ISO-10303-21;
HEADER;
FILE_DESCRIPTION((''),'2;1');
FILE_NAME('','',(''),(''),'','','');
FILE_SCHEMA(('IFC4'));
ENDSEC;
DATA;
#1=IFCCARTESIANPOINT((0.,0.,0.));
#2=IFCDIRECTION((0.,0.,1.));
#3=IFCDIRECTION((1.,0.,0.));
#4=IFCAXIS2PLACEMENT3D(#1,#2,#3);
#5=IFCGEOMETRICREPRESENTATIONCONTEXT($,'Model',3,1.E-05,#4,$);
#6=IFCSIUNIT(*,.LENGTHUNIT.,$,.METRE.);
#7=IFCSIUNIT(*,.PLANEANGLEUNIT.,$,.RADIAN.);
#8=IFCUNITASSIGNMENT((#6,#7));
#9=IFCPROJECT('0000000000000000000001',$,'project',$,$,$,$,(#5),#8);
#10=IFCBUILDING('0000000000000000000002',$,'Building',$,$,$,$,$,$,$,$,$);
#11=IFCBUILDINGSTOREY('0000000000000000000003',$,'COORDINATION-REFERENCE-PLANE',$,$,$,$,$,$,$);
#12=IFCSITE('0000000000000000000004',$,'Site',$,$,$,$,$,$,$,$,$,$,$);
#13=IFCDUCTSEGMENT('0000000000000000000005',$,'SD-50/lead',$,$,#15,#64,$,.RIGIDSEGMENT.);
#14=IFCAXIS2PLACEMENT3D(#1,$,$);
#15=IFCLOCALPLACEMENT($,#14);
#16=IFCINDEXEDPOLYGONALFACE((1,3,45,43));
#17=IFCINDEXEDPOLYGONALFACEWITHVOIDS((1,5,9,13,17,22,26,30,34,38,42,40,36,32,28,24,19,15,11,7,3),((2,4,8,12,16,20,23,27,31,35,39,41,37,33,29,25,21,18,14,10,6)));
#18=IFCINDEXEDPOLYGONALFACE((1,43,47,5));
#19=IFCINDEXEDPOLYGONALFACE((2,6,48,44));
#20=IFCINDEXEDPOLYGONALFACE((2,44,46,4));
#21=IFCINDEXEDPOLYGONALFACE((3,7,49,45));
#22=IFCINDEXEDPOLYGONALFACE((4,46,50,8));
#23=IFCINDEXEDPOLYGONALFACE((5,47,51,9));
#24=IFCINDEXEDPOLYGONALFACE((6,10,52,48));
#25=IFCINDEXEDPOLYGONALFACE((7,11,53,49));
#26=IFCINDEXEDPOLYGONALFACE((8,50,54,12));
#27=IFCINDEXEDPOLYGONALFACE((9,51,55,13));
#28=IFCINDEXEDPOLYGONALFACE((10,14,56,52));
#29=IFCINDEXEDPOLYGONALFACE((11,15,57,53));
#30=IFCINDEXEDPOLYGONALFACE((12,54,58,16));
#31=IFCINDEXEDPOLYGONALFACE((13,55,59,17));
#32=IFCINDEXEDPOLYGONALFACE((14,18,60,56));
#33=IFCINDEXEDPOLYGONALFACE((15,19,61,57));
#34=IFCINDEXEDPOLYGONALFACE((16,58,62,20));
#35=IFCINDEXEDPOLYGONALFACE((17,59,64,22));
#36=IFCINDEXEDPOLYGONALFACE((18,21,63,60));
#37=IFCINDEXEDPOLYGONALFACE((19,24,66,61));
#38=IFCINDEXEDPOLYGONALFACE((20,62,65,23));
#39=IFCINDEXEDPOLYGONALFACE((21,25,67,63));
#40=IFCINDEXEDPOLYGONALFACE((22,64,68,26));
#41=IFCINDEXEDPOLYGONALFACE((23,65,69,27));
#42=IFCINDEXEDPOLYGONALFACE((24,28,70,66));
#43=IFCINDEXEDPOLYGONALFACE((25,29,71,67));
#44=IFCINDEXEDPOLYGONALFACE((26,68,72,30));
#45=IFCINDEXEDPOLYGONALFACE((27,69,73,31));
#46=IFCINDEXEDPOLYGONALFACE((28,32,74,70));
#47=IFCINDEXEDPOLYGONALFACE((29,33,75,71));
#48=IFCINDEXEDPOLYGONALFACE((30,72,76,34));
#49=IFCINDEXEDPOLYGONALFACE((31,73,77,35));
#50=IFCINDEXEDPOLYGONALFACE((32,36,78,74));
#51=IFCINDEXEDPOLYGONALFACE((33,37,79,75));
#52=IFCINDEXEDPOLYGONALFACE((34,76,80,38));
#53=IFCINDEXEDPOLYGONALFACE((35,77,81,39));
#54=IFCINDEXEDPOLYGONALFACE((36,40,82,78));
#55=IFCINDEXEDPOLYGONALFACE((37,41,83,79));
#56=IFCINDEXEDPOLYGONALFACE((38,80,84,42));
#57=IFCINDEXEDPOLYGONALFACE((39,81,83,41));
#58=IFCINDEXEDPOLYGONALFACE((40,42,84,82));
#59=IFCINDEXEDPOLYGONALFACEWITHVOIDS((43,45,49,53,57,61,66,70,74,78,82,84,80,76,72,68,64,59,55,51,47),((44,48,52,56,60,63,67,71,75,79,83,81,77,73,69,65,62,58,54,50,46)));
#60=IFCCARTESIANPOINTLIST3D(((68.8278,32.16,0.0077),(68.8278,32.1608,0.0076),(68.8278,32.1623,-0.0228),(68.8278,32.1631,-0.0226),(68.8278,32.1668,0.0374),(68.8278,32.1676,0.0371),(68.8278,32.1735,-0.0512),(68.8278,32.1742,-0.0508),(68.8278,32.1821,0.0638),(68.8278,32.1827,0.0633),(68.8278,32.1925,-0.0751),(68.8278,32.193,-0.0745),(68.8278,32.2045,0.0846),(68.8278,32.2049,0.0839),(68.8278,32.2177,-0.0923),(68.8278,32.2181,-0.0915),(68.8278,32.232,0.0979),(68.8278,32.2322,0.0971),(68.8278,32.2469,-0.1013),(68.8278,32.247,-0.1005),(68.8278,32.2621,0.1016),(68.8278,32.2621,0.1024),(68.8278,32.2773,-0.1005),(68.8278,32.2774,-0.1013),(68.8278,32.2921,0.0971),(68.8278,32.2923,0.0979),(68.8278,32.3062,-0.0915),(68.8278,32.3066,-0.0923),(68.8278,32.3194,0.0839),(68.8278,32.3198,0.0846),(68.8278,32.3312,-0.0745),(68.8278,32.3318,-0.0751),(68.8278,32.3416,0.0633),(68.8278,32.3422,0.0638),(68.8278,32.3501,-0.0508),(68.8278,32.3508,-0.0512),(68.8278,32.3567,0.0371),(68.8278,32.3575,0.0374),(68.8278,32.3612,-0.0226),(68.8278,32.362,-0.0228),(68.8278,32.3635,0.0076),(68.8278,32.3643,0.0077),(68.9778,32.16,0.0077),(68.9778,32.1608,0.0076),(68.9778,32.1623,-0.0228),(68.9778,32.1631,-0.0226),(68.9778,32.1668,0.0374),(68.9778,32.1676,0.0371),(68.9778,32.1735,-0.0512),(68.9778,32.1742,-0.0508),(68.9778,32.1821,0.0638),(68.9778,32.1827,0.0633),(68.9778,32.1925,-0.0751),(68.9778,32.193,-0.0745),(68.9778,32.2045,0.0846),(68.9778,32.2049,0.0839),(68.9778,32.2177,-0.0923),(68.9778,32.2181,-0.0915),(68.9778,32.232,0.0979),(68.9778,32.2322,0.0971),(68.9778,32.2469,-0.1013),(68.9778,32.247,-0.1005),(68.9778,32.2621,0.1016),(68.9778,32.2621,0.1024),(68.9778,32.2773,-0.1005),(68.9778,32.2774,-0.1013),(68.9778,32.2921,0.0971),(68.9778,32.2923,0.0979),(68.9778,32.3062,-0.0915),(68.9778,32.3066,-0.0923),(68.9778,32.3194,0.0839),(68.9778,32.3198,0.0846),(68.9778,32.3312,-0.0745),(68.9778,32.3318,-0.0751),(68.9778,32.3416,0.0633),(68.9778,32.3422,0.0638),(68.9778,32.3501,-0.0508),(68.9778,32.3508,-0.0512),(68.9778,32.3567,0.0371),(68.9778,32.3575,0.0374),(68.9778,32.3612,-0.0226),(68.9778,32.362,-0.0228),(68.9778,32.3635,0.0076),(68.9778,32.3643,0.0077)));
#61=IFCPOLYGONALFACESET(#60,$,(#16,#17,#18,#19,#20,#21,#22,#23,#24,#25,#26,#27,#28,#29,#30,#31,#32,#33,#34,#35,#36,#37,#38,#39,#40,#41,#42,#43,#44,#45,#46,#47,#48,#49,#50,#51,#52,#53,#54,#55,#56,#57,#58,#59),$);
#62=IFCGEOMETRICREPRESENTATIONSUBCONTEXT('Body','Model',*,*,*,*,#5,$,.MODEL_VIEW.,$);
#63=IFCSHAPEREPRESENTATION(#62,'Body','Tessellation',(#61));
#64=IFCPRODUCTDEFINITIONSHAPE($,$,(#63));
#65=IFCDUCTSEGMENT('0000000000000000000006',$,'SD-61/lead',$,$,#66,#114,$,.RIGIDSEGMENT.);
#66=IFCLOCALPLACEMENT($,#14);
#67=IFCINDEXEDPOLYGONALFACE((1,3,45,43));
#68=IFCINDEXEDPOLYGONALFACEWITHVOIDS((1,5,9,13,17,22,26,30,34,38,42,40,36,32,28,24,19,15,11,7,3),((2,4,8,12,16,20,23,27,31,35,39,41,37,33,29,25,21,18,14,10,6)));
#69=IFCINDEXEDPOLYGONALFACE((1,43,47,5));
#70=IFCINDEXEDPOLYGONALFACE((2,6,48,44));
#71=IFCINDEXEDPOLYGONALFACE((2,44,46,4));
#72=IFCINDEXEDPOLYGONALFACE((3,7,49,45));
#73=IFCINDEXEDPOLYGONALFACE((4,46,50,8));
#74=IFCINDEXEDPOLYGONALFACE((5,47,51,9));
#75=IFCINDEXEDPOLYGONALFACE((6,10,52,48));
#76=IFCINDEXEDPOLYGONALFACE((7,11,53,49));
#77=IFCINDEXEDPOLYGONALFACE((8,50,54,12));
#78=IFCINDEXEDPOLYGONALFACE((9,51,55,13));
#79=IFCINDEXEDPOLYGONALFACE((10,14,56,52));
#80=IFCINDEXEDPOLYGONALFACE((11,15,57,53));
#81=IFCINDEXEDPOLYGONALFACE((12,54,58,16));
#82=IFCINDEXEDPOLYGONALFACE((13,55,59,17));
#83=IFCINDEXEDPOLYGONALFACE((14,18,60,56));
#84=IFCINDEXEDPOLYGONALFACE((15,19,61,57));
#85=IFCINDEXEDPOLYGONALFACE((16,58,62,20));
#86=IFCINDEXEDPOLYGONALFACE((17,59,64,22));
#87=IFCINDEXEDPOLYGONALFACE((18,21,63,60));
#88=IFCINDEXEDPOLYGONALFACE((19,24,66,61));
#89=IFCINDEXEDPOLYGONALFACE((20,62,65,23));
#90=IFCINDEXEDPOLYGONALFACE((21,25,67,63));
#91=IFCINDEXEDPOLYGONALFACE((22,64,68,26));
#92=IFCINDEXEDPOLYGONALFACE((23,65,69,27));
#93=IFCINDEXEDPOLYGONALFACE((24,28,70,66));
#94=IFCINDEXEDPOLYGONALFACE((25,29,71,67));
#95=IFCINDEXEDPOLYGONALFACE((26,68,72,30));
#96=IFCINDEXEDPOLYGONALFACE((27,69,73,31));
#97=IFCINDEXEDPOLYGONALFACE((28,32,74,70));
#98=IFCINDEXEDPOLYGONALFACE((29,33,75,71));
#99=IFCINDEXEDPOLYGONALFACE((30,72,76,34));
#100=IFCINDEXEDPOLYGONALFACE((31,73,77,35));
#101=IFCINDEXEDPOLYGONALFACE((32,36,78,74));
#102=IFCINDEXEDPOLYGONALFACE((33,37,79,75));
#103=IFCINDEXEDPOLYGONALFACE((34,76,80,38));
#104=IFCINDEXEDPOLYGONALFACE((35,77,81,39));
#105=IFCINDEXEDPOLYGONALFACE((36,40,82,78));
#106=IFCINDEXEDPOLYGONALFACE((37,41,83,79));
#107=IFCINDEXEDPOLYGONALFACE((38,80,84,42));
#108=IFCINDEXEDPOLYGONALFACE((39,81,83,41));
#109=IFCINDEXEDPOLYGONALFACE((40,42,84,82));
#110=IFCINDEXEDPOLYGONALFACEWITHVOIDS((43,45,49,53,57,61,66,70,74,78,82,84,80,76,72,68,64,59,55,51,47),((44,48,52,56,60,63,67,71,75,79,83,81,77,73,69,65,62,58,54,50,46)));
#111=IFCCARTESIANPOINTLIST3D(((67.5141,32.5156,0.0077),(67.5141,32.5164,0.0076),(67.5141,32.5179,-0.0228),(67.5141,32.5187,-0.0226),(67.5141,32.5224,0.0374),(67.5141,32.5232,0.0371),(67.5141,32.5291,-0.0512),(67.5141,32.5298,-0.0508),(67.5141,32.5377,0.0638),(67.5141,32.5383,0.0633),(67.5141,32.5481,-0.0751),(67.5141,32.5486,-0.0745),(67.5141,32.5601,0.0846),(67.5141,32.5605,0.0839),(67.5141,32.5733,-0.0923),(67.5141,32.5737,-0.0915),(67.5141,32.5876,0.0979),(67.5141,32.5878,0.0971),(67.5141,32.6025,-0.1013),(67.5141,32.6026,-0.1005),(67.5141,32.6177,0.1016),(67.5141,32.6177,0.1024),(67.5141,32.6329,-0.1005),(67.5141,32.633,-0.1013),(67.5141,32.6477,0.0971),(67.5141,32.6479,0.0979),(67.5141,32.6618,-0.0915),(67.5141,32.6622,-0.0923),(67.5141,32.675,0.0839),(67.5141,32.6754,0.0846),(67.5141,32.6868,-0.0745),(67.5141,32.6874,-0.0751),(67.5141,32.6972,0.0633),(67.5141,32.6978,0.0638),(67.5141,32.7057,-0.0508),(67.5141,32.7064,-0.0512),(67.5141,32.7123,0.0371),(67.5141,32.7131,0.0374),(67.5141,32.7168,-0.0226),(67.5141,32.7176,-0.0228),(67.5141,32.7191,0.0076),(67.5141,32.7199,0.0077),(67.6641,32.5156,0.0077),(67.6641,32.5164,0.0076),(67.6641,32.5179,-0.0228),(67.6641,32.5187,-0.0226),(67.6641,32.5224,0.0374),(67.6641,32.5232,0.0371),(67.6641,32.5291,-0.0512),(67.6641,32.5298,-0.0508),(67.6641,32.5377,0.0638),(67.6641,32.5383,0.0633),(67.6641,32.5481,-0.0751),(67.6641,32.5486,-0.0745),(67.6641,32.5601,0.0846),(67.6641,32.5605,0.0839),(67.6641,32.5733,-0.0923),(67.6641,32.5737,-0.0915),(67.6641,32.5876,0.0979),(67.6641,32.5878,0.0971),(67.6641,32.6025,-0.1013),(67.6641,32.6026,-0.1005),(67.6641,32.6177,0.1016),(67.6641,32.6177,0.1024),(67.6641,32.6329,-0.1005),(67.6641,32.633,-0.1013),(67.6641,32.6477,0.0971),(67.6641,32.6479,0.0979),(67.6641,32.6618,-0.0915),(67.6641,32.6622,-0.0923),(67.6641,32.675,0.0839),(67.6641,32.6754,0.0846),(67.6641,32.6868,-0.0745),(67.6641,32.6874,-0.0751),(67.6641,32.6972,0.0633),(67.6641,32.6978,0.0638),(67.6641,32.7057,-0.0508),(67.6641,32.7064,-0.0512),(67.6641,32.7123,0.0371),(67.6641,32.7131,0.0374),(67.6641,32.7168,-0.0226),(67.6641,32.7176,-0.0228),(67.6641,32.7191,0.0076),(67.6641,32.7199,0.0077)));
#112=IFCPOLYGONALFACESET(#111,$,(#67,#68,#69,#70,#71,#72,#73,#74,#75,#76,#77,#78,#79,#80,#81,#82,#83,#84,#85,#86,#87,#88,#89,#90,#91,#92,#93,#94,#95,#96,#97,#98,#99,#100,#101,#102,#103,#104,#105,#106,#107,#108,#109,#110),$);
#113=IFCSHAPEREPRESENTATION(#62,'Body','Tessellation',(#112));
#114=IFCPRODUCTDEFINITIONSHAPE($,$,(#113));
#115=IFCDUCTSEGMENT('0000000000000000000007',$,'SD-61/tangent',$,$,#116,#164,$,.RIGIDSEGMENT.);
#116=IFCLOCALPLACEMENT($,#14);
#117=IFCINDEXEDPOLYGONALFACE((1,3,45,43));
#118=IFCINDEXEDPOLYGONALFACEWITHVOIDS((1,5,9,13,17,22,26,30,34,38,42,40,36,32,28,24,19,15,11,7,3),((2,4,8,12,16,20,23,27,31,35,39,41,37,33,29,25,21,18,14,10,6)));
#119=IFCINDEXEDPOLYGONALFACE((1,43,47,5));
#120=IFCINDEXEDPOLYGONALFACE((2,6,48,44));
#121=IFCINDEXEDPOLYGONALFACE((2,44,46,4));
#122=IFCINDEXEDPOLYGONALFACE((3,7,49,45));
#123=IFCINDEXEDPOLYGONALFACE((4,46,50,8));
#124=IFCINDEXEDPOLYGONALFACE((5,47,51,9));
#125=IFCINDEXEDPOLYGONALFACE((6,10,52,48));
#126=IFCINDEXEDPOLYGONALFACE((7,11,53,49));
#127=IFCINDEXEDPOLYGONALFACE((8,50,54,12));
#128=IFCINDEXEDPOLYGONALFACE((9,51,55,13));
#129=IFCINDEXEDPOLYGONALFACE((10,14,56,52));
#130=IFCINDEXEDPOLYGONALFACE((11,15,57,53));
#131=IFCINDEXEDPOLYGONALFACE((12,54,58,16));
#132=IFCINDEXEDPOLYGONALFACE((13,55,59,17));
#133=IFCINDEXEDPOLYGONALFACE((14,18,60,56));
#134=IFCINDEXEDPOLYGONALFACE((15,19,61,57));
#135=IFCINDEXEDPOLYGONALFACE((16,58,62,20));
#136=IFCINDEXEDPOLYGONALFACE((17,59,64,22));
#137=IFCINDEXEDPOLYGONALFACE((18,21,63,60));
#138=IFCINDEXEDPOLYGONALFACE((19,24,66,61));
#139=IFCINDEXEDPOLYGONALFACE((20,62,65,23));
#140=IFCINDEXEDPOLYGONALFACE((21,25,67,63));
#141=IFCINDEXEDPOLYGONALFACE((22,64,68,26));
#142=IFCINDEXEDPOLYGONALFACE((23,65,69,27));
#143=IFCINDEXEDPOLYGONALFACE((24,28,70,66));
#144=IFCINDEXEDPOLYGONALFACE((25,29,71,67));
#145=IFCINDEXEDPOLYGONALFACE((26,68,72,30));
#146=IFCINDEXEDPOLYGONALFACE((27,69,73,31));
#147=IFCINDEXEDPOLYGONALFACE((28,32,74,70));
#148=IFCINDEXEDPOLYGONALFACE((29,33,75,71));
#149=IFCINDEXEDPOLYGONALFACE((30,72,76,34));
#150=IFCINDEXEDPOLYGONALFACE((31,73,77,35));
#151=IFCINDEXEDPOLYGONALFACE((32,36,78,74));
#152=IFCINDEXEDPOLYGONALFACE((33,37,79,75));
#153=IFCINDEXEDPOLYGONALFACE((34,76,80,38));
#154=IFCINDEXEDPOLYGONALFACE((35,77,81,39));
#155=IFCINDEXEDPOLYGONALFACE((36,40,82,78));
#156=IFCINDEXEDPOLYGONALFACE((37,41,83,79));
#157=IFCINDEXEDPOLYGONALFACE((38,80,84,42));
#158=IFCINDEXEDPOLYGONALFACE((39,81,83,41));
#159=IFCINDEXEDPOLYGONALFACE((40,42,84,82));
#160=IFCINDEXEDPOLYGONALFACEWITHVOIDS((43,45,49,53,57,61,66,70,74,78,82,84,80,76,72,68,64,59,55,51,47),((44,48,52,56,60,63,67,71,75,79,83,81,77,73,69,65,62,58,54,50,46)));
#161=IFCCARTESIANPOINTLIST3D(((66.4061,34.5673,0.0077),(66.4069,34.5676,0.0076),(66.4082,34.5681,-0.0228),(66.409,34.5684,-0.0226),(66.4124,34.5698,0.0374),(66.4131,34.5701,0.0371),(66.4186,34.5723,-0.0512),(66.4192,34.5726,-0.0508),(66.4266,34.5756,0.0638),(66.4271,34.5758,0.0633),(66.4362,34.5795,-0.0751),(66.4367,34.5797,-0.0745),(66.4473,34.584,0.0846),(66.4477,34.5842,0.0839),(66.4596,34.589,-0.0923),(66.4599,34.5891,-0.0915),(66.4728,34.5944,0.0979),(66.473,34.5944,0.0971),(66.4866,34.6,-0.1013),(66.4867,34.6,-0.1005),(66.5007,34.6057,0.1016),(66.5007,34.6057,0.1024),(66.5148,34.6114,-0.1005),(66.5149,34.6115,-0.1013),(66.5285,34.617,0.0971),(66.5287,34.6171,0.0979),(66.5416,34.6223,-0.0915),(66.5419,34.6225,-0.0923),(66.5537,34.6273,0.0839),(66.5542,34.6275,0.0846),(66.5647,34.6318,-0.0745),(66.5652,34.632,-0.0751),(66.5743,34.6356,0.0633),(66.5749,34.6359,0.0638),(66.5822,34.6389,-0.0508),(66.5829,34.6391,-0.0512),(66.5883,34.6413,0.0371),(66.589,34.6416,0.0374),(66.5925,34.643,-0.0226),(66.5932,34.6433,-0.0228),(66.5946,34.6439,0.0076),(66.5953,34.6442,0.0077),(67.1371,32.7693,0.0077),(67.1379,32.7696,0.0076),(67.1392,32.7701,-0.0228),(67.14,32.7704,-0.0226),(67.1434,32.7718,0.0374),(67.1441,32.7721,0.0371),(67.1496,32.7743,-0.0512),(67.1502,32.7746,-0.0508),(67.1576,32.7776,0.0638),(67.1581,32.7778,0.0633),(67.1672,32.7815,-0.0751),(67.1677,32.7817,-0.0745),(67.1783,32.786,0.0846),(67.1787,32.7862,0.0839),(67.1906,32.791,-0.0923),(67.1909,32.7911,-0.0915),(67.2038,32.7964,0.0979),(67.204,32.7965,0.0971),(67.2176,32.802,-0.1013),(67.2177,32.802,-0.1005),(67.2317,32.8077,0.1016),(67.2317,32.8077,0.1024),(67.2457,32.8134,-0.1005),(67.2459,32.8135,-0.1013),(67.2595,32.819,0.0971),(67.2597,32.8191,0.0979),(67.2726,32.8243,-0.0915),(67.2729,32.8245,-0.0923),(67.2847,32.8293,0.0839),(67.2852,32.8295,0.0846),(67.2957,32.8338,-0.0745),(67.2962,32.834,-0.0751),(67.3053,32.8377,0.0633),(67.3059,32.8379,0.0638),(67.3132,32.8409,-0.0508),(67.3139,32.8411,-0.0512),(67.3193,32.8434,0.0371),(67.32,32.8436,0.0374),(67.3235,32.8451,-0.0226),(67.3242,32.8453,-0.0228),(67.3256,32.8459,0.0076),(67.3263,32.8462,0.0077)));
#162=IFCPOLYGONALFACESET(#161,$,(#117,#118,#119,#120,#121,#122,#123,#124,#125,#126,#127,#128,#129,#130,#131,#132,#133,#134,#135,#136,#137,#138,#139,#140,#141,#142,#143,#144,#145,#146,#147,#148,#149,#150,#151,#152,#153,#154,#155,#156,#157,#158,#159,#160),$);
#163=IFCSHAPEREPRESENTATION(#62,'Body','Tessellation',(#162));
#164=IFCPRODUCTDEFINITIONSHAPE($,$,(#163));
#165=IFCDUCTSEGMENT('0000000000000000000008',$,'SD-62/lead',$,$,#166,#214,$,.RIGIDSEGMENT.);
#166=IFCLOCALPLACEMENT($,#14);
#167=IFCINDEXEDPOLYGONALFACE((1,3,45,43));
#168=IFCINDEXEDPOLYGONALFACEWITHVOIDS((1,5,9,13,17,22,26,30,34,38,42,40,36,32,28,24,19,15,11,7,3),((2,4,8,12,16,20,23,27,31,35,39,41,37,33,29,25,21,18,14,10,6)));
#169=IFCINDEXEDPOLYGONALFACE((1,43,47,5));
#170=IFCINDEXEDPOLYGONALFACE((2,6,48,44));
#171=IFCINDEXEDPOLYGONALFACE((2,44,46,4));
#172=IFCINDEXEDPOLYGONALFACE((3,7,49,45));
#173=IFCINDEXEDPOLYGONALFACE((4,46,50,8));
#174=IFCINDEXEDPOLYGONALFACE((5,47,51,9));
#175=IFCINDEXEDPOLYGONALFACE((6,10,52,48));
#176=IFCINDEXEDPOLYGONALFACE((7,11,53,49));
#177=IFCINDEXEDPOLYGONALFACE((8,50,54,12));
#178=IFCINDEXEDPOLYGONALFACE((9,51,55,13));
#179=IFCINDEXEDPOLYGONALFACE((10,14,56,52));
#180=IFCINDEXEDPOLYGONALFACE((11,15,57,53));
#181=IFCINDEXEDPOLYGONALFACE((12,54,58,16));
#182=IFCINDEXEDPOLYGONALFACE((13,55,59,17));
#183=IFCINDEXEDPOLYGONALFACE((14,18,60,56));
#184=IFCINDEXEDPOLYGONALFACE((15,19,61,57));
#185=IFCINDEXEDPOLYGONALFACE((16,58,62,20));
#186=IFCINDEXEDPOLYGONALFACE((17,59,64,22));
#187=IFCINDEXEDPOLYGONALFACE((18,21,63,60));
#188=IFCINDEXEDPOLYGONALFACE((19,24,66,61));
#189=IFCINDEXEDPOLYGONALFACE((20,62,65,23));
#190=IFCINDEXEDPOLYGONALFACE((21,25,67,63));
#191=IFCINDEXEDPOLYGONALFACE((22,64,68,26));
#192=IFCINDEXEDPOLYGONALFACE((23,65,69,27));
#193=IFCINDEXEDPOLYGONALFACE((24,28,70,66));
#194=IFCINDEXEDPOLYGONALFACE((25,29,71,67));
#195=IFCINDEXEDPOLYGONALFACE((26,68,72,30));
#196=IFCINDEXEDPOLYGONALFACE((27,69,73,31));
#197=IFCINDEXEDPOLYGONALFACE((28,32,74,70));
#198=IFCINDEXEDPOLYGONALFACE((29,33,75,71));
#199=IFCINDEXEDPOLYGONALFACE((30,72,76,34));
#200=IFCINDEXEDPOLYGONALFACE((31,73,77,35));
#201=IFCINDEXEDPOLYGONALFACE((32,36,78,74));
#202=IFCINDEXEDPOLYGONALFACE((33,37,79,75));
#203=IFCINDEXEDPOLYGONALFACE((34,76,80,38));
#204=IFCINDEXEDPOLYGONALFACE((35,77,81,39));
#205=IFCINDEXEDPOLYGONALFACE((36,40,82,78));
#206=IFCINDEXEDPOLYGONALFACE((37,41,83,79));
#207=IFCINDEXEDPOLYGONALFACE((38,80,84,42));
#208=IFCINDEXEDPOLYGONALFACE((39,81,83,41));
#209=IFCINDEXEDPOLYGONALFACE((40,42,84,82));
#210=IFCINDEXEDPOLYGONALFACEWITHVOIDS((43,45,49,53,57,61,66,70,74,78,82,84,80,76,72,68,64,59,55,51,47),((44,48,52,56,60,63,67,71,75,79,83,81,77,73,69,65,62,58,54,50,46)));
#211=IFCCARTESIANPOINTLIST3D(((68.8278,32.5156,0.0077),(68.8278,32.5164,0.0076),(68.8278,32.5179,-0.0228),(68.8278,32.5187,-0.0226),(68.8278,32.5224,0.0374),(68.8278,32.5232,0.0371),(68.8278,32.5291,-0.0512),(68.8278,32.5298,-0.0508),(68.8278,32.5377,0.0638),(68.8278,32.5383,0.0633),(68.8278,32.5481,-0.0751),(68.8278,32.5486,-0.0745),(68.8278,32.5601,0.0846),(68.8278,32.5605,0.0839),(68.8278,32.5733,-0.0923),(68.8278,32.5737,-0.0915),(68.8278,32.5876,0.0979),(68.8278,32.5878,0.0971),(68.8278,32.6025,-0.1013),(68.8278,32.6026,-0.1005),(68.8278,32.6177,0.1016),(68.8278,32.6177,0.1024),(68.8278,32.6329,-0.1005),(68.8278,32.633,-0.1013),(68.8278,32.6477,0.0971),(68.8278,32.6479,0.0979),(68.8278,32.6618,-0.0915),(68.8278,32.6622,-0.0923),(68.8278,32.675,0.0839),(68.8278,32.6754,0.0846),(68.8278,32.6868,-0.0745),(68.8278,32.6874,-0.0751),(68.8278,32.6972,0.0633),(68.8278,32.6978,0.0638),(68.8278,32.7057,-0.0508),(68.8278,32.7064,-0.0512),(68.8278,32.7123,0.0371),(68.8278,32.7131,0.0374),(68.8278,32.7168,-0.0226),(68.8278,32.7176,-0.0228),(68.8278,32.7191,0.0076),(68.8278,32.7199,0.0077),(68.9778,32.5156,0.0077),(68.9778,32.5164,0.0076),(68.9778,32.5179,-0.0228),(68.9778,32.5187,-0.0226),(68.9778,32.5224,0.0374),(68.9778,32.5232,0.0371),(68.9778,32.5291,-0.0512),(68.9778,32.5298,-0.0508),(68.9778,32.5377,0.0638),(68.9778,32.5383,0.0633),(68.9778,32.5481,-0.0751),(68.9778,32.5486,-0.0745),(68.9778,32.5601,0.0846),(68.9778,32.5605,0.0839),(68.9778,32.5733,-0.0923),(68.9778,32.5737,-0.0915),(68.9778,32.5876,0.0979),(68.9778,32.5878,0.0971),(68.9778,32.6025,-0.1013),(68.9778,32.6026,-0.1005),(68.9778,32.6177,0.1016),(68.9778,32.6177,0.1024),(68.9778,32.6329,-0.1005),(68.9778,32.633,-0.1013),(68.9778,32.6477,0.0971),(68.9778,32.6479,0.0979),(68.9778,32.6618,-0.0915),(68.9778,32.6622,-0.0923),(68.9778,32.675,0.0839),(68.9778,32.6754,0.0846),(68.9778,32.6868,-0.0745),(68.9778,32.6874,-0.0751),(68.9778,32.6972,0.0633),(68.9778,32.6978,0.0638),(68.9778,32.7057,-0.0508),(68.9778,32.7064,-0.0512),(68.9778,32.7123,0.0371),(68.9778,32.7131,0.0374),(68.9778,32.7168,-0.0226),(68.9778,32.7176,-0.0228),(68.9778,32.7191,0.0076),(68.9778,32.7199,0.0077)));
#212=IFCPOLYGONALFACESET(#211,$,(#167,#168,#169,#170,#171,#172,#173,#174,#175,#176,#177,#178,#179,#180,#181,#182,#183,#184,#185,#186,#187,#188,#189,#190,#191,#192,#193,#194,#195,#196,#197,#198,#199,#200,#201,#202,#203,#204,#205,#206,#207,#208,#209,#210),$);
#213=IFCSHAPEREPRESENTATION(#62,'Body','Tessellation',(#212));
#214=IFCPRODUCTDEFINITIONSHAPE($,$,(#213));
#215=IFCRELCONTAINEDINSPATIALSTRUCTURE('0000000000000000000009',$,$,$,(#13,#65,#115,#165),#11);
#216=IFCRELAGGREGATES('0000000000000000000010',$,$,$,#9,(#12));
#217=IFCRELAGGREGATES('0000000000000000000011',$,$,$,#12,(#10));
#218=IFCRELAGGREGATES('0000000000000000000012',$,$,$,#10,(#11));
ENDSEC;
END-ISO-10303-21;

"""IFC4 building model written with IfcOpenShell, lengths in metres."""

from ifc_helpers import new_model, si_unit, frame, origin_with_axes, place, context, subcontext, project, spatial, hollow_circle, extrude, element, save


model = new_model("IFC4")

# Units and contexts
model_context = context("Model", 3, precision=1e-05, world=origin_with_axes())
body_context_1 = subcontext(model_context, "Body", "Model", "MODEL_VIEW")
ifc_project = project(units=[si_unit("LENGTHUNIT", "METRE"), si_unit("PLANEANGLEUNIT", "RADIAN")], contexts=[model_context])

# Site, building, storey
site = spatial("IfcSite", under=ifc_project, Name="Site")
building = spatial("IfcBuilding", under=site, Name="Building")
storey = spatial("IfcBuildingStorey", under=building, Name="COORDINATION-REFERENCE-PLANE")

# Duct segments
for number, where, z_axis, x_axis, name in (
    (1, (68.8278, 32.2621, 0.0), (1.0, 0.0, 0.0), (0.0, 0.0, 1.0), "SD-50/lead"),
    (2, (67.6641, 32.6177, 0.0), (-1.0, 0.0, 0.0), (0.0, 0.0, 1.0), "SD-61/lead"),
):
    element("IfcDuctSegment", number, at=place(None, frame(where, z_axis=z_axis, x_axis=x_axis)), inside=storey, Name=name, PredefinedType="RIGIDSEGMENT", context=body_context_1, shape_type="SweptSolid", body=[
        extrude(hollow_circle(Radius=0.1024, WallThickness=0.0008), origin_with_axes(), (0.0, 0.0, 1.0), 0.15),
    ])

# Duct segment
duct_segment_1_placement = place(None, frame((67.2317, 32.8077, 0.0), z_axis=(-0.376625, 0.926366, 0.0), x_axis=(0.0, 0.0, 1.0)))
element("IfcDuctSegment", 3, at=duct_segment_1_placement, inside=storey, Name="SD-61/tangent", PredefinedType="RIGIDSEGMENT", context=body_context_1, shape_type="SweptSolid", body=[
    extrude(hollow_circle(Radius=0.1024, WallThickness=0.0008), origin_with_axes(), (0.0, 0.0, 1.0), 1.9409),
])

# Duct segment
duct_segment_2_placement = place(None, frame((68.8278, 32.6177, 0.0), z_axis=(1.0, 0.0, 0.0), x_axis=(0.0, 0.0, 1.0)))
element("IfcDuctSegment", 4, at=duct_segment_2_placement, inside=storey, Name="SD-62/lead", PredefinedType="RIGIDSEGMENT", context=body_context_1, shape_type="SweptSolid", body=[
    extrude(hollow_circle(Radius=0.1024, WallThickness=0.0008), origin_with_axes(), (0.0, 0.0, 1.0), 0.15),
])

save(model, "model.ifc")
